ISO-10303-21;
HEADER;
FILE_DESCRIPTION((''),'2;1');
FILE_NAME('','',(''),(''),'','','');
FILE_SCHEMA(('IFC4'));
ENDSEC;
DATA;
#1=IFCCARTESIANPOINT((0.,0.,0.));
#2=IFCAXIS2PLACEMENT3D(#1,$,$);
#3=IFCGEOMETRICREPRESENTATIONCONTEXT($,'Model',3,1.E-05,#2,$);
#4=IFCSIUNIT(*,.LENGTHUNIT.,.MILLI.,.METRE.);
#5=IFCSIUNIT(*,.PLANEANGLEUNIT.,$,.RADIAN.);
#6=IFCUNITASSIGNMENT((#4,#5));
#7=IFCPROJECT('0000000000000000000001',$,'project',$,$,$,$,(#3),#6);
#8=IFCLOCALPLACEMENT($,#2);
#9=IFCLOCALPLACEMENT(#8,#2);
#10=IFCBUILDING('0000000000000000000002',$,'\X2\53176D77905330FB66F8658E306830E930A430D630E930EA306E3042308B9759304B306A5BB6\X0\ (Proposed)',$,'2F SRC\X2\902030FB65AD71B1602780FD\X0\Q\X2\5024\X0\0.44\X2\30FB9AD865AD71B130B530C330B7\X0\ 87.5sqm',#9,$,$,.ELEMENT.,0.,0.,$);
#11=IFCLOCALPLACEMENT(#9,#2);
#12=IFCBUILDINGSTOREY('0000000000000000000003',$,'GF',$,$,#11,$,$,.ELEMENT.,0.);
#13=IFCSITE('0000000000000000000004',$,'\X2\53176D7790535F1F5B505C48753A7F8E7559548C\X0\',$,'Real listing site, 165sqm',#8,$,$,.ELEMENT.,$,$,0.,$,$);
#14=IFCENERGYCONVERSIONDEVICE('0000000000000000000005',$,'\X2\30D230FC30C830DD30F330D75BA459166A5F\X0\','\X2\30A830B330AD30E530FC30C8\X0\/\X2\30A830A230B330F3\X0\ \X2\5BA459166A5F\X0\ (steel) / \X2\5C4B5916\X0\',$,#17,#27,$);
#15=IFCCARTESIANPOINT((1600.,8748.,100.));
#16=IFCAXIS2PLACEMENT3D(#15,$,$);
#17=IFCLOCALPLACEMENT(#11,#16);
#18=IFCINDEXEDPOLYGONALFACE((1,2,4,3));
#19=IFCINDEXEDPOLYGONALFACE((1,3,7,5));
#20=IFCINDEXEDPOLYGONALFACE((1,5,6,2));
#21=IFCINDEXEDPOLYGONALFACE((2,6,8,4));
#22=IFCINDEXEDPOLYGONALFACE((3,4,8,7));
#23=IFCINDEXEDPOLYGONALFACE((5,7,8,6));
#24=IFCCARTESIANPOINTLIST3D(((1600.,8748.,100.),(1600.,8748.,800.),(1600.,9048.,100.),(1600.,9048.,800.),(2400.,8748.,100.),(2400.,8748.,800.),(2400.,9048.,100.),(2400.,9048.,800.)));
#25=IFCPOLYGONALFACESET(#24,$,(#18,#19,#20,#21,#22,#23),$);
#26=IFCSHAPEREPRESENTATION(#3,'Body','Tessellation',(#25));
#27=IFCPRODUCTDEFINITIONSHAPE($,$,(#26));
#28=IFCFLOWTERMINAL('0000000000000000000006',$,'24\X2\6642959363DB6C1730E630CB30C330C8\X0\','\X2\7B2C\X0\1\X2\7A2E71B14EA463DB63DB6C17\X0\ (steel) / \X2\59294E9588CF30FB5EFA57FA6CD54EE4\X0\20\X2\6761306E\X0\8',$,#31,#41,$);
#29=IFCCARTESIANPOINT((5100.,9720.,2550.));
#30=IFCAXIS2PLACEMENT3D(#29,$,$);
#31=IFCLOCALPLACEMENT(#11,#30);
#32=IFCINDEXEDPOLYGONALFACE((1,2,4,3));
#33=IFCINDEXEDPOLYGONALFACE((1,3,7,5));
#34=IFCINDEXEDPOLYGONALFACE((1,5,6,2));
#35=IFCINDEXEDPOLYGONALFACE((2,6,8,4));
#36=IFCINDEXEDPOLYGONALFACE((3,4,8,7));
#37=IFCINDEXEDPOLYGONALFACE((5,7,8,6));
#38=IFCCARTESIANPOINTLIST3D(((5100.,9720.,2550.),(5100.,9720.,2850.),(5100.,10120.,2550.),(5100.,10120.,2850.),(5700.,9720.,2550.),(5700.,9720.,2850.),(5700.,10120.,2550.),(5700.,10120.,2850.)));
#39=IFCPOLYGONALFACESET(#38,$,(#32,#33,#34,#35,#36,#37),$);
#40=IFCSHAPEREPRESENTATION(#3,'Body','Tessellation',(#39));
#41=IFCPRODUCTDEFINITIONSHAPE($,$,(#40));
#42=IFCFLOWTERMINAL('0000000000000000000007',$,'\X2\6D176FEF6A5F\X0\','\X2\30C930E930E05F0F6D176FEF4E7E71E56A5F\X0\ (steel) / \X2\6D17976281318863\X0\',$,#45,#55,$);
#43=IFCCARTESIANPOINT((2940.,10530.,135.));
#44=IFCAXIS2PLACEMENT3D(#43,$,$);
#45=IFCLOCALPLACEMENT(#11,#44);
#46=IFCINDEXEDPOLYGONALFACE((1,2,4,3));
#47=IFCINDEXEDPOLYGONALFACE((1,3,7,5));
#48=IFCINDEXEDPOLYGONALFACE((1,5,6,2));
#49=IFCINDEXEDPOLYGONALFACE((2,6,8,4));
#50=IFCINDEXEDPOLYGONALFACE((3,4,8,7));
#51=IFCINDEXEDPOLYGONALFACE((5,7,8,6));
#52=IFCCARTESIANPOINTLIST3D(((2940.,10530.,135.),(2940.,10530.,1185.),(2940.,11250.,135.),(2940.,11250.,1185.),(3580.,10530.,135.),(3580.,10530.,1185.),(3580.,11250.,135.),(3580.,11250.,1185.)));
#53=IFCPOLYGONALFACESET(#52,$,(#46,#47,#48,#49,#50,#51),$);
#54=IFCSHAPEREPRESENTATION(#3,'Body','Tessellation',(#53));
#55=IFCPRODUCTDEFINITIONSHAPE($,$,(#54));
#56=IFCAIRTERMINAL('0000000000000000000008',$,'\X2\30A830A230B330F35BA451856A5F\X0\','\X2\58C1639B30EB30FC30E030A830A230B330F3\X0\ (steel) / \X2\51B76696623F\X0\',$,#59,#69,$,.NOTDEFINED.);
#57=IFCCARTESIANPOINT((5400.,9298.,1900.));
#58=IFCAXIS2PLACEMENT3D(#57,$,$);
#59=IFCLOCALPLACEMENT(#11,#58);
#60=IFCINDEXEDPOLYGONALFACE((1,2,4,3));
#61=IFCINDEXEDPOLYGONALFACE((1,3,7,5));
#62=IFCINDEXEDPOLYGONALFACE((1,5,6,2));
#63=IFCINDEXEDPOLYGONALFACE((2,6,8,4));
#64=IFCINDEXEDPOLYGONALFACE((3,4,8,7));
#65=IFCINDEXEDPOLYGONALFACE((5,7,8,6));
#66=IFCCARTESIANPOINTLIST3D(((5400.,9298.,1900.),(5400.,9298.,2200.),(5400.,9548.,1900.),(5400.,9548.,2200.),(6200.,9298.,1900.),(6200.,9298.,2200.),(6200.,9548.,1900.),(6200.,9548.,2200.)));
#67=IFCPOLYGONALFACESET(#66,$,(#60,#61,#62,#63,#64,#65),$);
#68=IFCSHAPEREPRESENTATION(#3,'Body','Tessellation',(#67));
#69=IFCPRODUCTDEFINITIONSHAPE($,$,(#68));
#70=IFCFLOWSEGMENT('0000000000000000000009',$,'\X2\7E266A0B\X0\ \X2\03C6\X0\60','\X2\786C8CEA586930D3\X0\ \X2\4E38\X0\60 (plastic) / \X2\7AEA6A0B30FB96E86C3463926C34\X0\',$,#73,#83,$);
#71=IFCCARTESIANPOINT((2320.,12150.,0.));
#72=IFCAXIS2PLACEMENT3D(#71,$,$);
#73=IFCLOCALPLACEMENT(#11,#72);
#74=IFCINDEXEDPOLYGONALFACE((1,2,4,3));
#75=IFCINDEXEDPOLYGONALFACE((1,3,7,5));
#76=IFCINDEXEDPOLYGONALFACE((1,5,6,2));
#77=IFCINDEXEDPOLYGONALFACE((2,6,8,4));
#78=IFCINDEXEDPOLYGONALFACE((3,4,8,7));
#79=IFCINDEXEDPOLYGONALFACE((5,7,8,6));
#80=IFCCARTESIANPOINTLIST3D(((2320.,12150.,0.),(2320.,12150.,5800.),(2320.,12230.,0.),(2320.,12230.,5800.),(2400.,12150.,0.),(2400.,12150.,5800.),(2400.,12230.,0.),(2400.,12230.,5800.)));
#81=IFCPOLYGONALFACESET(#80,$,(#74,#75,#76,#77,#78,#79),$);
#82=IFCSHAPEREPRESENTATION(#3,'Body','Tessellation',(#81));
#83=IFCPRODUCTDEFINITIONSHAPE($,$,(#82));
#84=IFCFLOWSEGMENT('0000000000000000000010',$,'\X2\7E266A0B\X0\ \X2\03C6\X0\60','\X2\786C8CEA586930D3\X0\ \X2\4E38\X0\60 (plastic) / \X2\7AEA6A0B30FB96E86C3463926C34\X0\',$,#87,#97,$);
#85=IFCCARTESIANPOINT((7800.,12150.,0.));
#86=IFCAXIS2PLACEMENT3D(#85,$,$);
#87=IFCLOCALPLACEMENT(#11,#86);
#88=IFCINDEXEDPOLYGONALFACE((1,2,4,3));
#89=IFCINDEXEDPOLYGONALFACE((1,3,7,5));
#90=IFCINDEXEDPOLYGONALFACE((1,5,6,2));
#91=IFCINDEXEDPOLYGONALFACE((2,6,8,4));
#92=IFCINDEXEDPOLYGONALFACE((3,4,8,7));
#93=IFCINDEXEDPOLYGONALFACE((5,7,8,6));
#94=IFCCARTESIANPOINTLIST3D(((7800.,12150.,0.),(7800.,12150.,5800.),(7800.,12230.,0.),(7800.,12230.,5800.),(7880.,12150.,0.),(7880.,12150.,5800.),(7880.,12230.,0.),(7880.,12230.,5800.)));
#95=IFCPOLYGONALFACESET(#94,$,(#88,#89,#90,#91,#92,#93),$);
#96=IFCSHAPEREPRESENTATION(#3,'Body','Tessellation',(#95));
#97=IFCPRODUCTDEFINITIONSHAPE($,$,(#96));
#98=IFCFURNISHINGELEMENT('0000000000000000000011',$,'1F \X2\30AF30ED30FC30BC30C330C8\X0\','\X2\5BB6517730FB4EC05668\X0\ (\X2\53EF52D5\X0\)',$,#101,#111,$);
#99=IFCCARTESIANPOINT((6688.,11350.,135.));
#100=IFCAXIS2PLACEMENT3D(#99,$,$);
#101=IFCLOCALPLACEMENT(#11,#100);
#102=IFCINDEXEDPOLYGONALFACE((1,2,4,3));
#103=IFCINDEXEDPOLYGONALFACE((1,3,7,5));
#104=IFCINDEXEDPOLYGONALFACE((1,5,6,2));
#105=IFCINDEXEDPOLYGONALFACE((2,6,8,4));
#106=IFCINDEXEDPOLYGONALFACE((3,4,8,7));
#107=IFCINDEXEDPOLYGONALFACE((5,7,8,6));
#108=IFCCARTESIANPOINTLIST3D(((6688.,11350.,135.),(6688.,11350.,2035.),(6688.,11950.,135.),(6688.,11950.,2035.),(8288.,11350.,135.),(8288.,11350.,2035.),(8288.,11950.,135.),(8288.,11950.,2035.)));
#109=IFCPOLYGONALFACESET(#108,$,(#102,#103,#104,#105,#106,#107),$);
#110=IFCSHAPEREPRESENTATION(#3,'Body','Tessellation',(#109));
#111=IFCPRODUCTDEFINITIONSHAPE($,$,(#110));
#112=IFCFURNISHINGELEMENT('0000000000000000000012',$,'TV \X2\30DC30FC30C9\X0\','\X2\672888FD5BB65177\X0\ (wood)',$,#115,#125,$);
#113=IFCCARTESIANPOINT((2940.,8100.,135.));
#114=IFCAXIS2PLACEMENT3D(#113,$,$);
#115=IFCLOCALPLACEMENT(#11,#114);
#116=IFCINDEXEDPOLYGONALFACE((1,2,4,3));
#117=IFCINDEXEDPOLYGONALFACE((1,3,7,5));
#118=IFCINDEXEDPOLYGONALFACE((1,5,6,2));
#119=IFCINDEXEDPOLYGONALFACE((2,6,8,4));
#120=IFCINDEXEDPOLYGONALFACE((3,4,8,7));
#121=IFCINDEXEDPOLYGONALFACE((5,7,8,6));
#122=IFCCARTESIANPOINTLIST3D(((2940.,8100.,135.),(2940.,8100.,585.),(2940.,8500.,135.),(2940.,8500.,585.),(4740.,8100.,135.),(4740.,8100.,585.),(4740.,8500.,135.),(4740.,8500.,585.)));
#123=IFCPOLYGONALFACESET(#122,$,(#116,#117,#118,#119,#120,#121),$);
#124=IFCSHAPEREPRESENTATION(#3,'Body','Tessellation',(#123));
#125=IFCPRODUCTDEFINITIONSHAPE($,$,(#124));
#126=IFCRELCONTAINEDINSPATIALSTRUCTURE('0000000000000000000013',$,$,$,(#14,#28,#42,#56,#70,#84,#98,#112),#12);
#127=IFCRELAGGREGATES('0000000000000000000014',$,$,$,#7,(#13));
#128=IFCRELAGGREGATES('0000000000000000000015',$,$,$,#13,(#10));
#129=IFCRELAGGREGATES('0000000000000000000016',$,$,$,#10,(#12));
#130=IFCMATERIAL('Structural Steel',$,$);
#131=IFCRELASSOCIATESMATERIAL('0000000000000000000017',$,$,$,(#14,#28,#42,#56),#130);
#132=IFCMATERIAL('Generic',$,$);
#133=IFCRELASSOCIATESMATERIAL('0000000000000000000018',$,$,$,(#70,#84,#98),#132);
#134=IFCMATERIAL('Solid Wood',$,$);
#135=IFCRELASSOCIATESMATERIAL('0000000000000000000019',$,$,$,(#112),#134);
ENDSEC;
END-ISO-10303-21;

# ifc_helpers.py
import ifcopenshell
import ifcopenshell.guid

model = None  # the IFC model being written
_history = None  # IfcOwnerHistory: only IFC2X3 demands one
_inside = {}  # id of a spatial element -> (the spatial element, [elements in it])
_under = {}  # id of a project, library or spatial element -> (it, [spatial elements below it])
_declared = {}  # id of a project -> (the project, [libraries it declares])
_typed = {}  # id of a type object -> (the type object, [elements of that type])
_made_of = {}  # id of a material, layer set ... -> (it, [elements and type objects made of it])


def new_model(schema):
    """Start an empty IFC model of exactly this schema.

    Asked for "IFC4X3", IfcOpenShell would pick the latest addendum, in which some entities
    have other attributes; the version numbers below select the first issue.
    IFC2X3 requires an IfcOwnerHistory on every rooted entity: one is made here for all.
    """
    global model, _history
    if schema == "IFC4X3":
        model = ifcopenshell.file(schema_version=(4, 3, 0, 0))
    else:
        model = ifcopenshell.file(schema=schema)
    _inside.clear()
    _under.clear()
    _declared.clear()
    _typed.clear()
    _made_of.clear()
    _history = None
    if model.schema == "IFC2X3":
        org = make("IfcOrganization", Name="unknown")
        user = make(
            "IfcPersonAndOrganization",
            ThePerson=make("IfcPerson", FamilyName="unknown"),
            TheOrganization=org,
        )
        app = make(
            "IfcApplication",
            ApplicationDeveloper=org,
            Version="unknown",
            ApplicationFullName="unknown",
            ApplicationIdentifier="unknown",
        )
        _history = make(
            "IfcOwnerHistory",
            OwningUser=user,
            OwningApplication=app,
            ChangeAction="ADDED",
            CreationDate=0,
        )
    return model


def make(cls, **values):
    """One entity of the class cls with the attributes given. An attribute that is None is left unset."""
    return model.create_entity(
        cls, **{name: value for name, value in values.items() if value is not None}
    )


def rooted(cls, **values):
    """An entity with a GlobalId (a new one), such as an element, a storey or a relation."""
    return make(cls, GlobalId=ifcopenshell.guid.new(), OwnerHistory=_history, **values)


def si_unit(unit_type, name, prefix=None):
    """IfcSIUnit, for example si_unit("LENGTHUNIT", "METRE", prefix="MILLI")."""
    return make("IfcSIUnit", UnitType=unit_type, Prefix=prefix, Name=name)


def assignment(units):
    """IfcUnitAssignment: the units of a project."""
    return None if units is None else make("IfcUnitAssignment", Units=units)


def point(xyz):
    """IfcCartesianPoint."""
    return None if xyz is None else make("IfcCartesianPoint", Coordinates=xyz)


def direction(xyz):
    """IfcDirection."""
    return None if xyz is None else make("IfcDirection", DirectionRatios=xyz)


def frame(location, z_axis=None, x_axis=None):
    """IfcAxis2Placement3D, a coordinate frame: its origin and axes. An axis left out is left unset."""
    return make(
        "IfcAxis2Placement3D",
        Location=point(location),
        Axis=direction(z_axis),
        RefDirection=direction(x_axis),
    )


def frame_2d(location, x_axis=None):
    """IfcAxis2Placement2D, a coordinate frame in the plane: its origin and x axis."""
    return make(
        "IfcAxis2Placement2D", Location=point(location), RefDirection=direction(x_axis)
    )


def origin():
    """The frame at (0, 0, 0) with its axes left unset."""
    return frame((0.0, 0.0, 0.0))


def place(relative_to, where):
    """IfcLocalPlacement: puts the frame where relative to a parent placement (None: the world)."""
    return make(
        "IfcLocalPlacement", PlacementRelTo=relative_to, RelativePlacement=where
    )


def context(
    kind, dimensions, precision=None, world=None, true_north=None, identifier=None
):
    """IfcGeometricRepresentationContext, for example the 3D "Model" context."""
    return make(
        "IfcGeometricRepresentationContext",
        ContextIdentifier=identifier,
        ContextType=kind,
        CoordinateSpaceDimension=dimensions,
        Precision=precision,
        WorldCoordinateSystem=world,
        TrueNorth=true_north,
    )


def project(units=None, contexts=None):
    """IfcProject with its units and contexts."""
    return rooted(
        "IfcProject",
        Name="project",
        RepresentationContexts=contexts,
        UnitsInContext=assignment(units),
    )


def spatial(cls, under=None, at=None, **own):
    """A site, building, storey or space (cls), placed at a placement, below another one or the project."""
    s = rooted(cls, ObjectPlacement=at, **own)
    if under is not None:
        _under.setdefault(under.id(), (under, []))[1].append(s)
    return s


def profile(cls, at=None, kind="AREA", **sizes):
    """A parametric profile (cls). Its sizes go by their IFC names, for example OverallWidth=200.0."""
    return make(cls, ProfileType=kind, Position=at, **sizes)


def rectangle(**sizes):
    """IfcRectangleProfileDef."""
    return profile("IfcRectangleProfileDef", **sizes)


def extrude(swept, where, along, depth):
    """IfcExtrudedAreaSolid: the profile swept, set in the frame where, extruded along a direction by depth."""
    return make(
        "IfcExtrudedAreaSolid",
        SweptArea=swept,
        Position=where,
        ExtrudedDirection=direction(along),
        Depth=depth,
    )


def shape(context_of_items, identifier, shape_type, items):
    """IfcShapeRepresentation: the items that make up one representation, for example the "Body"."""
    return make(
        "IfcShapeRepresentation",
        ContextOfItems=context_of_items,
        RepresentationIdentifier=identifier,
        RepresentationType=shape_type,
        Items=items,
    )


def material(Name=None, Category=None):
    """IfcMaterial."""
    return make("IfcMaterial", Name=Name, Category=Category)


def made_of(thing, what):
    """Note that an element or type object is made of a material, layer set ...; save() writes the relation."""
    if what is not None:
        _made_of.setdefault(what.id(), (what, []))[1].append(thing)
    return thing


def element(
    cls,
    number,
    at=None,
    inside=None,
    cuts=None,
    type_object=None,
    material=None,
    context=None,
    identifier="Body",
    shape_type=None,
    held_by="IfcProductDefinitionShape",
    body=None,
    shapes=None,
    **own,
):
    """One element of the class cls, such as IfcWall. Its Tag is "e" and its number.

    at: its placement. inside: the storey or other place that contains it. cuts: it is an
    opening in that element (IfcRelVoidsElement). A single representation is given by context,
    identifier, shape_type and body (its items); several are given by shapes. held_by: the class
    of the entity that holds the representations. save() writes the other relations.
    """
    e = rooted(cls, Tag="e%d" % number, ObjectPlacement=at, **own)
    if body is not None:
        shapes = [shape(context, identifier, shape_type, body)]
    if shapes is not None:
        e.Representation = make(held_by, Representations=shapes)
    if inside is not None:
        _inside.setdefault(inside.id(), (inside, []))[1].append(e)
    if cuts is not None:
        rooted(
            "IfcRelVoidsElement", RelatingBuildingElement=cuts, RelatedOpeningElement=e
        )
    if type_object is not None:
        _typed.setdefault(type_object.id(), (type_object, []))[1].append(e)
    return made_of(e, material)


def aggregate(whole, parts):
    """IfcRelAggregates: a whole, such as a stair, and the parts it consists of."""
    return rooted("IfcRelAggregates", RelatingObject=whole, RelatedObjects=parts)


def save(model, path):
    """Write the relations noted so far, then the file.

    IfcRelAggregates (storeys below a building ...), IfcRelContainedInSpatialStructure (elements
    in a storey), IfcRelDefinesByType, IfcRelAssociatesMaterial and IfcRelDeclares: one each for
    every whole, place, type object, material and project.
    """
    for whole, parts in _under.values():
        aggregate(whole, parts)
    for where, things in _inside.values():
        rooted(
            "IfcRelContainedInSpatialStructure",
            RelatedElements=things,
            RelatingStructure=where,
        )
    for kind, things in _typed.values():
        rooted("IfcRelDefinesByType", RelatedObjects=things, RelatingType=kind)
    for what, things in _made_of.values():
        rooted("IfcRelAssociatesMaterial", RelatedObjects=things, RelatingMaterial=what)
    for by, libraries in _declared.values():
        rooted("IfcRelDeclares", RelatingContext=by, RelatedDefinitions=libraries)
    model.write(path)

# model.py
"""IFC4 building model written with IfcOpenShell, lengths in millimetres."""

from ifc_helpers import new_model, si_unit, frame, frame_2d, origin, place, context, project, spatial, rectangle, extrude, material, element, save


model = new_model("IFC4")

# Units and contexts
model_context = context("Model", 3, precision=1e-05, world=origin())
ifc_project = project(units=[si_unit("LENGTHUNIT", "METRE", prefix="MILLI"), si_unit("PLANEANGLEUNIT", "RADIAN")], contexts=[model_context])

# Site, building, storey
site_placement = place(None, origin())
site = spatial("IfcSite", under=ifc_project, at=site_placement, Name="北海道弟子屈町美留和", ObjectType="Real listing site, 165sqm", CompositionType="ELEMENT", RefElevation=0.0)
building_placement = place(site_placement, origin())
building = spatial("IfcBuilding", under=site, at=building_placement, Name="北海道・書斎とライブラリのある静かな家 (Proposed)", ObjectType="2F SRC造・断熱性能Q値0.44・高断熱サッシ 87.5sqm", CompositionType="ELEMENT", ElevationOfRefHeight=0.0, ElevationOfTerrain=0.0)
storey_placement = place(building_placement, origin())
storey = spatial("IfcBuildingStorey", under=building, at=storey_placement, Name="GF", CompositionType="ELEMENT", Elevation=0.0)

# Shared definitions
ifc_material_1 = material(Name="Solid Wood")

# Shared definitions
ifc_material_2 = material(Name="Generic")

# Shared definitions
ifc_material_3 = material(Name="Structural Steel")

# Energy conversion device
energy_conversion_device_placement = place(storey_placement, frame((1600.0, 8748.0, 100.0)))
element("IfcEnergyConversionDevice", 1, at=energy_conversion_device_placement, inside=storey, material=ifc_material_3, Name="ヒートポンプ室外機", Description="エコキュート/エアコン 室外機 (steel) / 屋外", context=model_context, shape_type="SweptSolid", body=[
    extrude(rectangle(XDim=800.0, YDim=300.0, at=frame_2d((400.0, 150.0))), frame((1600.0, 8748.0, 100.0)), (0.0, 0.0, 1.0), 700.0),
])

# Flow terminals
flow_terminal_1_placement = place(storey_placement, frame((5100.0, 9720.0, 2550.0)))
element("IfcFlowTerminal", 2, at=flow_terminal_1_placement, inside=storey, material=ifc_material_3, Name="24時間換気ユニット", Description="第1種熱交換換気 (steel) / 天井裏・建基法令20条の8", context=model_context, shape_type="SweptSolid", body=[
    extrude(rectangle(XDim=600.0, YDim=400.0, at=frame_2d((300.0, 200.0))), frame((5100.0, 9720.0, 2550.0)), (0.0, 0.0, 1.0), 300.0),
])
flow_terminal_2_placement = place(storey_placement, frame((2940.0, 10530.0, 135.0)))
element("IfcFlowTerminal", 3, at=flow_terminal_2_placement, inside=storey, material=ifc_material_3, Name="洗濯機", Description="ドラム式洗濯乾燥機 (steel) / 洗面脱衣", context=model_context, shape_type="SweptSolid", body=[
    extrude(rectangle(XDim=640.0, YDim=720.0, at=frame_2d((320.0, 360.0))), frame((2940.0, 10530.0, 135.0)), (0.0, 0.0, 1.0), 1050.0),
])

# Air terminal
air_terminal_placement = place(storey_placement, frame((5400.0, 9298.0, 1900.0)))
element("IfcAirTerminal", 4, at=air_terminal_placement, inside=storey, material=ifc_material_3, Name="エアコン室内機", Description="壁掛ルームエアコン (steel) / 冷暖房", PredefinedType="NOTDEFINED", context=model_context, shape_type="SweptSolid", body=[
    extrude(rectangle(XDim=800.0, YDim=250.0, at=frame_2d((400.0, 125.0))), frame((5400.0, 9298.0, 1900.0)), (0.0, 0.0, 1.0), 300.0),
])

# Flow segments
flow_segment_1_placement = place(storey_placement, frame((2320.0, 12150.0, 0.0)))
element("IfcFlowSegment", 5, at=flow_segment_1_placement, inside=storey, material=ifc_material_2, Name="縦樋 φ60", Description="硬質塩ビ 丸60 (plastic) / 竪樋・雨水排水", context=model_context, shape_type="SweptSolid", body=[
    extrude(rectangle(XDim=80.0, YDim=80.0, at=frame_2d((40.0, 40.0))), frame((2320.0, 12150.0, 0.0)), (0.0, 0.0, 1.0), 5800.0),
])
flow_segment_2_placement = place(storey_placement, frame((7800.0, 12150.0, 0.0)))
element("IfcFlowSegment", 6, at=flow_segment_2_placement, inside=storey, material=ifc_material_2, Name="縦樋 φ60", Description="硬質塩ビ 丸60 (plastic) / 竪樋・雨水排水", context=model_context, shape_type="SweptSolid", body=[
    extrude(rectangle(XDim=80.0, YDim=80.0, at=frame_2d((40.0, 40.0))), frame((7800.0, 12150.0, 0.0)), (0.0, 0.0, 1.0), 5800.0),
])

# Furnishing elements
furnishing_1_placement = place(storey_placement, frame((6688.0, 11350.0, 135.0)))
element("IfcFurnishingElement", 7, at=furnishing_1_placement, inside=storey, material=ifc_material_2, Name="1F クローゼット", Description="家具・什器 (可動)", context=model_context, shape_type="SweptSolid", body=[
    extrude(rectangle(XDim=1600.0, YDim=600.0, at=frame_2d((800.0, 300.0))), frame((6688.0, 11350.0, 135.0)), (0.0, 0.0, 1.0), 1900.0),
])
furnishing_2_placement = place(storey_placement, frame((2940.0, 8100.0, 135.0)))
element("IfcFurnishingElement", 8, at=furnishing_2_placement, inside=storey, material=ifc_material_1, Name="TV ボード", Description="木製家具 (wood)", context=model_context, shape_type="SweptSolid", body=[
    extrude(rectangle(XDim=1800.0, YDim=400.0, at=frame_2d((900.0, 200.0))), frame((2940.0, 8100.0, 135.0)), (0.0, 0.0, 1.0), 450.0),
])

save(model, "model.ifc")
